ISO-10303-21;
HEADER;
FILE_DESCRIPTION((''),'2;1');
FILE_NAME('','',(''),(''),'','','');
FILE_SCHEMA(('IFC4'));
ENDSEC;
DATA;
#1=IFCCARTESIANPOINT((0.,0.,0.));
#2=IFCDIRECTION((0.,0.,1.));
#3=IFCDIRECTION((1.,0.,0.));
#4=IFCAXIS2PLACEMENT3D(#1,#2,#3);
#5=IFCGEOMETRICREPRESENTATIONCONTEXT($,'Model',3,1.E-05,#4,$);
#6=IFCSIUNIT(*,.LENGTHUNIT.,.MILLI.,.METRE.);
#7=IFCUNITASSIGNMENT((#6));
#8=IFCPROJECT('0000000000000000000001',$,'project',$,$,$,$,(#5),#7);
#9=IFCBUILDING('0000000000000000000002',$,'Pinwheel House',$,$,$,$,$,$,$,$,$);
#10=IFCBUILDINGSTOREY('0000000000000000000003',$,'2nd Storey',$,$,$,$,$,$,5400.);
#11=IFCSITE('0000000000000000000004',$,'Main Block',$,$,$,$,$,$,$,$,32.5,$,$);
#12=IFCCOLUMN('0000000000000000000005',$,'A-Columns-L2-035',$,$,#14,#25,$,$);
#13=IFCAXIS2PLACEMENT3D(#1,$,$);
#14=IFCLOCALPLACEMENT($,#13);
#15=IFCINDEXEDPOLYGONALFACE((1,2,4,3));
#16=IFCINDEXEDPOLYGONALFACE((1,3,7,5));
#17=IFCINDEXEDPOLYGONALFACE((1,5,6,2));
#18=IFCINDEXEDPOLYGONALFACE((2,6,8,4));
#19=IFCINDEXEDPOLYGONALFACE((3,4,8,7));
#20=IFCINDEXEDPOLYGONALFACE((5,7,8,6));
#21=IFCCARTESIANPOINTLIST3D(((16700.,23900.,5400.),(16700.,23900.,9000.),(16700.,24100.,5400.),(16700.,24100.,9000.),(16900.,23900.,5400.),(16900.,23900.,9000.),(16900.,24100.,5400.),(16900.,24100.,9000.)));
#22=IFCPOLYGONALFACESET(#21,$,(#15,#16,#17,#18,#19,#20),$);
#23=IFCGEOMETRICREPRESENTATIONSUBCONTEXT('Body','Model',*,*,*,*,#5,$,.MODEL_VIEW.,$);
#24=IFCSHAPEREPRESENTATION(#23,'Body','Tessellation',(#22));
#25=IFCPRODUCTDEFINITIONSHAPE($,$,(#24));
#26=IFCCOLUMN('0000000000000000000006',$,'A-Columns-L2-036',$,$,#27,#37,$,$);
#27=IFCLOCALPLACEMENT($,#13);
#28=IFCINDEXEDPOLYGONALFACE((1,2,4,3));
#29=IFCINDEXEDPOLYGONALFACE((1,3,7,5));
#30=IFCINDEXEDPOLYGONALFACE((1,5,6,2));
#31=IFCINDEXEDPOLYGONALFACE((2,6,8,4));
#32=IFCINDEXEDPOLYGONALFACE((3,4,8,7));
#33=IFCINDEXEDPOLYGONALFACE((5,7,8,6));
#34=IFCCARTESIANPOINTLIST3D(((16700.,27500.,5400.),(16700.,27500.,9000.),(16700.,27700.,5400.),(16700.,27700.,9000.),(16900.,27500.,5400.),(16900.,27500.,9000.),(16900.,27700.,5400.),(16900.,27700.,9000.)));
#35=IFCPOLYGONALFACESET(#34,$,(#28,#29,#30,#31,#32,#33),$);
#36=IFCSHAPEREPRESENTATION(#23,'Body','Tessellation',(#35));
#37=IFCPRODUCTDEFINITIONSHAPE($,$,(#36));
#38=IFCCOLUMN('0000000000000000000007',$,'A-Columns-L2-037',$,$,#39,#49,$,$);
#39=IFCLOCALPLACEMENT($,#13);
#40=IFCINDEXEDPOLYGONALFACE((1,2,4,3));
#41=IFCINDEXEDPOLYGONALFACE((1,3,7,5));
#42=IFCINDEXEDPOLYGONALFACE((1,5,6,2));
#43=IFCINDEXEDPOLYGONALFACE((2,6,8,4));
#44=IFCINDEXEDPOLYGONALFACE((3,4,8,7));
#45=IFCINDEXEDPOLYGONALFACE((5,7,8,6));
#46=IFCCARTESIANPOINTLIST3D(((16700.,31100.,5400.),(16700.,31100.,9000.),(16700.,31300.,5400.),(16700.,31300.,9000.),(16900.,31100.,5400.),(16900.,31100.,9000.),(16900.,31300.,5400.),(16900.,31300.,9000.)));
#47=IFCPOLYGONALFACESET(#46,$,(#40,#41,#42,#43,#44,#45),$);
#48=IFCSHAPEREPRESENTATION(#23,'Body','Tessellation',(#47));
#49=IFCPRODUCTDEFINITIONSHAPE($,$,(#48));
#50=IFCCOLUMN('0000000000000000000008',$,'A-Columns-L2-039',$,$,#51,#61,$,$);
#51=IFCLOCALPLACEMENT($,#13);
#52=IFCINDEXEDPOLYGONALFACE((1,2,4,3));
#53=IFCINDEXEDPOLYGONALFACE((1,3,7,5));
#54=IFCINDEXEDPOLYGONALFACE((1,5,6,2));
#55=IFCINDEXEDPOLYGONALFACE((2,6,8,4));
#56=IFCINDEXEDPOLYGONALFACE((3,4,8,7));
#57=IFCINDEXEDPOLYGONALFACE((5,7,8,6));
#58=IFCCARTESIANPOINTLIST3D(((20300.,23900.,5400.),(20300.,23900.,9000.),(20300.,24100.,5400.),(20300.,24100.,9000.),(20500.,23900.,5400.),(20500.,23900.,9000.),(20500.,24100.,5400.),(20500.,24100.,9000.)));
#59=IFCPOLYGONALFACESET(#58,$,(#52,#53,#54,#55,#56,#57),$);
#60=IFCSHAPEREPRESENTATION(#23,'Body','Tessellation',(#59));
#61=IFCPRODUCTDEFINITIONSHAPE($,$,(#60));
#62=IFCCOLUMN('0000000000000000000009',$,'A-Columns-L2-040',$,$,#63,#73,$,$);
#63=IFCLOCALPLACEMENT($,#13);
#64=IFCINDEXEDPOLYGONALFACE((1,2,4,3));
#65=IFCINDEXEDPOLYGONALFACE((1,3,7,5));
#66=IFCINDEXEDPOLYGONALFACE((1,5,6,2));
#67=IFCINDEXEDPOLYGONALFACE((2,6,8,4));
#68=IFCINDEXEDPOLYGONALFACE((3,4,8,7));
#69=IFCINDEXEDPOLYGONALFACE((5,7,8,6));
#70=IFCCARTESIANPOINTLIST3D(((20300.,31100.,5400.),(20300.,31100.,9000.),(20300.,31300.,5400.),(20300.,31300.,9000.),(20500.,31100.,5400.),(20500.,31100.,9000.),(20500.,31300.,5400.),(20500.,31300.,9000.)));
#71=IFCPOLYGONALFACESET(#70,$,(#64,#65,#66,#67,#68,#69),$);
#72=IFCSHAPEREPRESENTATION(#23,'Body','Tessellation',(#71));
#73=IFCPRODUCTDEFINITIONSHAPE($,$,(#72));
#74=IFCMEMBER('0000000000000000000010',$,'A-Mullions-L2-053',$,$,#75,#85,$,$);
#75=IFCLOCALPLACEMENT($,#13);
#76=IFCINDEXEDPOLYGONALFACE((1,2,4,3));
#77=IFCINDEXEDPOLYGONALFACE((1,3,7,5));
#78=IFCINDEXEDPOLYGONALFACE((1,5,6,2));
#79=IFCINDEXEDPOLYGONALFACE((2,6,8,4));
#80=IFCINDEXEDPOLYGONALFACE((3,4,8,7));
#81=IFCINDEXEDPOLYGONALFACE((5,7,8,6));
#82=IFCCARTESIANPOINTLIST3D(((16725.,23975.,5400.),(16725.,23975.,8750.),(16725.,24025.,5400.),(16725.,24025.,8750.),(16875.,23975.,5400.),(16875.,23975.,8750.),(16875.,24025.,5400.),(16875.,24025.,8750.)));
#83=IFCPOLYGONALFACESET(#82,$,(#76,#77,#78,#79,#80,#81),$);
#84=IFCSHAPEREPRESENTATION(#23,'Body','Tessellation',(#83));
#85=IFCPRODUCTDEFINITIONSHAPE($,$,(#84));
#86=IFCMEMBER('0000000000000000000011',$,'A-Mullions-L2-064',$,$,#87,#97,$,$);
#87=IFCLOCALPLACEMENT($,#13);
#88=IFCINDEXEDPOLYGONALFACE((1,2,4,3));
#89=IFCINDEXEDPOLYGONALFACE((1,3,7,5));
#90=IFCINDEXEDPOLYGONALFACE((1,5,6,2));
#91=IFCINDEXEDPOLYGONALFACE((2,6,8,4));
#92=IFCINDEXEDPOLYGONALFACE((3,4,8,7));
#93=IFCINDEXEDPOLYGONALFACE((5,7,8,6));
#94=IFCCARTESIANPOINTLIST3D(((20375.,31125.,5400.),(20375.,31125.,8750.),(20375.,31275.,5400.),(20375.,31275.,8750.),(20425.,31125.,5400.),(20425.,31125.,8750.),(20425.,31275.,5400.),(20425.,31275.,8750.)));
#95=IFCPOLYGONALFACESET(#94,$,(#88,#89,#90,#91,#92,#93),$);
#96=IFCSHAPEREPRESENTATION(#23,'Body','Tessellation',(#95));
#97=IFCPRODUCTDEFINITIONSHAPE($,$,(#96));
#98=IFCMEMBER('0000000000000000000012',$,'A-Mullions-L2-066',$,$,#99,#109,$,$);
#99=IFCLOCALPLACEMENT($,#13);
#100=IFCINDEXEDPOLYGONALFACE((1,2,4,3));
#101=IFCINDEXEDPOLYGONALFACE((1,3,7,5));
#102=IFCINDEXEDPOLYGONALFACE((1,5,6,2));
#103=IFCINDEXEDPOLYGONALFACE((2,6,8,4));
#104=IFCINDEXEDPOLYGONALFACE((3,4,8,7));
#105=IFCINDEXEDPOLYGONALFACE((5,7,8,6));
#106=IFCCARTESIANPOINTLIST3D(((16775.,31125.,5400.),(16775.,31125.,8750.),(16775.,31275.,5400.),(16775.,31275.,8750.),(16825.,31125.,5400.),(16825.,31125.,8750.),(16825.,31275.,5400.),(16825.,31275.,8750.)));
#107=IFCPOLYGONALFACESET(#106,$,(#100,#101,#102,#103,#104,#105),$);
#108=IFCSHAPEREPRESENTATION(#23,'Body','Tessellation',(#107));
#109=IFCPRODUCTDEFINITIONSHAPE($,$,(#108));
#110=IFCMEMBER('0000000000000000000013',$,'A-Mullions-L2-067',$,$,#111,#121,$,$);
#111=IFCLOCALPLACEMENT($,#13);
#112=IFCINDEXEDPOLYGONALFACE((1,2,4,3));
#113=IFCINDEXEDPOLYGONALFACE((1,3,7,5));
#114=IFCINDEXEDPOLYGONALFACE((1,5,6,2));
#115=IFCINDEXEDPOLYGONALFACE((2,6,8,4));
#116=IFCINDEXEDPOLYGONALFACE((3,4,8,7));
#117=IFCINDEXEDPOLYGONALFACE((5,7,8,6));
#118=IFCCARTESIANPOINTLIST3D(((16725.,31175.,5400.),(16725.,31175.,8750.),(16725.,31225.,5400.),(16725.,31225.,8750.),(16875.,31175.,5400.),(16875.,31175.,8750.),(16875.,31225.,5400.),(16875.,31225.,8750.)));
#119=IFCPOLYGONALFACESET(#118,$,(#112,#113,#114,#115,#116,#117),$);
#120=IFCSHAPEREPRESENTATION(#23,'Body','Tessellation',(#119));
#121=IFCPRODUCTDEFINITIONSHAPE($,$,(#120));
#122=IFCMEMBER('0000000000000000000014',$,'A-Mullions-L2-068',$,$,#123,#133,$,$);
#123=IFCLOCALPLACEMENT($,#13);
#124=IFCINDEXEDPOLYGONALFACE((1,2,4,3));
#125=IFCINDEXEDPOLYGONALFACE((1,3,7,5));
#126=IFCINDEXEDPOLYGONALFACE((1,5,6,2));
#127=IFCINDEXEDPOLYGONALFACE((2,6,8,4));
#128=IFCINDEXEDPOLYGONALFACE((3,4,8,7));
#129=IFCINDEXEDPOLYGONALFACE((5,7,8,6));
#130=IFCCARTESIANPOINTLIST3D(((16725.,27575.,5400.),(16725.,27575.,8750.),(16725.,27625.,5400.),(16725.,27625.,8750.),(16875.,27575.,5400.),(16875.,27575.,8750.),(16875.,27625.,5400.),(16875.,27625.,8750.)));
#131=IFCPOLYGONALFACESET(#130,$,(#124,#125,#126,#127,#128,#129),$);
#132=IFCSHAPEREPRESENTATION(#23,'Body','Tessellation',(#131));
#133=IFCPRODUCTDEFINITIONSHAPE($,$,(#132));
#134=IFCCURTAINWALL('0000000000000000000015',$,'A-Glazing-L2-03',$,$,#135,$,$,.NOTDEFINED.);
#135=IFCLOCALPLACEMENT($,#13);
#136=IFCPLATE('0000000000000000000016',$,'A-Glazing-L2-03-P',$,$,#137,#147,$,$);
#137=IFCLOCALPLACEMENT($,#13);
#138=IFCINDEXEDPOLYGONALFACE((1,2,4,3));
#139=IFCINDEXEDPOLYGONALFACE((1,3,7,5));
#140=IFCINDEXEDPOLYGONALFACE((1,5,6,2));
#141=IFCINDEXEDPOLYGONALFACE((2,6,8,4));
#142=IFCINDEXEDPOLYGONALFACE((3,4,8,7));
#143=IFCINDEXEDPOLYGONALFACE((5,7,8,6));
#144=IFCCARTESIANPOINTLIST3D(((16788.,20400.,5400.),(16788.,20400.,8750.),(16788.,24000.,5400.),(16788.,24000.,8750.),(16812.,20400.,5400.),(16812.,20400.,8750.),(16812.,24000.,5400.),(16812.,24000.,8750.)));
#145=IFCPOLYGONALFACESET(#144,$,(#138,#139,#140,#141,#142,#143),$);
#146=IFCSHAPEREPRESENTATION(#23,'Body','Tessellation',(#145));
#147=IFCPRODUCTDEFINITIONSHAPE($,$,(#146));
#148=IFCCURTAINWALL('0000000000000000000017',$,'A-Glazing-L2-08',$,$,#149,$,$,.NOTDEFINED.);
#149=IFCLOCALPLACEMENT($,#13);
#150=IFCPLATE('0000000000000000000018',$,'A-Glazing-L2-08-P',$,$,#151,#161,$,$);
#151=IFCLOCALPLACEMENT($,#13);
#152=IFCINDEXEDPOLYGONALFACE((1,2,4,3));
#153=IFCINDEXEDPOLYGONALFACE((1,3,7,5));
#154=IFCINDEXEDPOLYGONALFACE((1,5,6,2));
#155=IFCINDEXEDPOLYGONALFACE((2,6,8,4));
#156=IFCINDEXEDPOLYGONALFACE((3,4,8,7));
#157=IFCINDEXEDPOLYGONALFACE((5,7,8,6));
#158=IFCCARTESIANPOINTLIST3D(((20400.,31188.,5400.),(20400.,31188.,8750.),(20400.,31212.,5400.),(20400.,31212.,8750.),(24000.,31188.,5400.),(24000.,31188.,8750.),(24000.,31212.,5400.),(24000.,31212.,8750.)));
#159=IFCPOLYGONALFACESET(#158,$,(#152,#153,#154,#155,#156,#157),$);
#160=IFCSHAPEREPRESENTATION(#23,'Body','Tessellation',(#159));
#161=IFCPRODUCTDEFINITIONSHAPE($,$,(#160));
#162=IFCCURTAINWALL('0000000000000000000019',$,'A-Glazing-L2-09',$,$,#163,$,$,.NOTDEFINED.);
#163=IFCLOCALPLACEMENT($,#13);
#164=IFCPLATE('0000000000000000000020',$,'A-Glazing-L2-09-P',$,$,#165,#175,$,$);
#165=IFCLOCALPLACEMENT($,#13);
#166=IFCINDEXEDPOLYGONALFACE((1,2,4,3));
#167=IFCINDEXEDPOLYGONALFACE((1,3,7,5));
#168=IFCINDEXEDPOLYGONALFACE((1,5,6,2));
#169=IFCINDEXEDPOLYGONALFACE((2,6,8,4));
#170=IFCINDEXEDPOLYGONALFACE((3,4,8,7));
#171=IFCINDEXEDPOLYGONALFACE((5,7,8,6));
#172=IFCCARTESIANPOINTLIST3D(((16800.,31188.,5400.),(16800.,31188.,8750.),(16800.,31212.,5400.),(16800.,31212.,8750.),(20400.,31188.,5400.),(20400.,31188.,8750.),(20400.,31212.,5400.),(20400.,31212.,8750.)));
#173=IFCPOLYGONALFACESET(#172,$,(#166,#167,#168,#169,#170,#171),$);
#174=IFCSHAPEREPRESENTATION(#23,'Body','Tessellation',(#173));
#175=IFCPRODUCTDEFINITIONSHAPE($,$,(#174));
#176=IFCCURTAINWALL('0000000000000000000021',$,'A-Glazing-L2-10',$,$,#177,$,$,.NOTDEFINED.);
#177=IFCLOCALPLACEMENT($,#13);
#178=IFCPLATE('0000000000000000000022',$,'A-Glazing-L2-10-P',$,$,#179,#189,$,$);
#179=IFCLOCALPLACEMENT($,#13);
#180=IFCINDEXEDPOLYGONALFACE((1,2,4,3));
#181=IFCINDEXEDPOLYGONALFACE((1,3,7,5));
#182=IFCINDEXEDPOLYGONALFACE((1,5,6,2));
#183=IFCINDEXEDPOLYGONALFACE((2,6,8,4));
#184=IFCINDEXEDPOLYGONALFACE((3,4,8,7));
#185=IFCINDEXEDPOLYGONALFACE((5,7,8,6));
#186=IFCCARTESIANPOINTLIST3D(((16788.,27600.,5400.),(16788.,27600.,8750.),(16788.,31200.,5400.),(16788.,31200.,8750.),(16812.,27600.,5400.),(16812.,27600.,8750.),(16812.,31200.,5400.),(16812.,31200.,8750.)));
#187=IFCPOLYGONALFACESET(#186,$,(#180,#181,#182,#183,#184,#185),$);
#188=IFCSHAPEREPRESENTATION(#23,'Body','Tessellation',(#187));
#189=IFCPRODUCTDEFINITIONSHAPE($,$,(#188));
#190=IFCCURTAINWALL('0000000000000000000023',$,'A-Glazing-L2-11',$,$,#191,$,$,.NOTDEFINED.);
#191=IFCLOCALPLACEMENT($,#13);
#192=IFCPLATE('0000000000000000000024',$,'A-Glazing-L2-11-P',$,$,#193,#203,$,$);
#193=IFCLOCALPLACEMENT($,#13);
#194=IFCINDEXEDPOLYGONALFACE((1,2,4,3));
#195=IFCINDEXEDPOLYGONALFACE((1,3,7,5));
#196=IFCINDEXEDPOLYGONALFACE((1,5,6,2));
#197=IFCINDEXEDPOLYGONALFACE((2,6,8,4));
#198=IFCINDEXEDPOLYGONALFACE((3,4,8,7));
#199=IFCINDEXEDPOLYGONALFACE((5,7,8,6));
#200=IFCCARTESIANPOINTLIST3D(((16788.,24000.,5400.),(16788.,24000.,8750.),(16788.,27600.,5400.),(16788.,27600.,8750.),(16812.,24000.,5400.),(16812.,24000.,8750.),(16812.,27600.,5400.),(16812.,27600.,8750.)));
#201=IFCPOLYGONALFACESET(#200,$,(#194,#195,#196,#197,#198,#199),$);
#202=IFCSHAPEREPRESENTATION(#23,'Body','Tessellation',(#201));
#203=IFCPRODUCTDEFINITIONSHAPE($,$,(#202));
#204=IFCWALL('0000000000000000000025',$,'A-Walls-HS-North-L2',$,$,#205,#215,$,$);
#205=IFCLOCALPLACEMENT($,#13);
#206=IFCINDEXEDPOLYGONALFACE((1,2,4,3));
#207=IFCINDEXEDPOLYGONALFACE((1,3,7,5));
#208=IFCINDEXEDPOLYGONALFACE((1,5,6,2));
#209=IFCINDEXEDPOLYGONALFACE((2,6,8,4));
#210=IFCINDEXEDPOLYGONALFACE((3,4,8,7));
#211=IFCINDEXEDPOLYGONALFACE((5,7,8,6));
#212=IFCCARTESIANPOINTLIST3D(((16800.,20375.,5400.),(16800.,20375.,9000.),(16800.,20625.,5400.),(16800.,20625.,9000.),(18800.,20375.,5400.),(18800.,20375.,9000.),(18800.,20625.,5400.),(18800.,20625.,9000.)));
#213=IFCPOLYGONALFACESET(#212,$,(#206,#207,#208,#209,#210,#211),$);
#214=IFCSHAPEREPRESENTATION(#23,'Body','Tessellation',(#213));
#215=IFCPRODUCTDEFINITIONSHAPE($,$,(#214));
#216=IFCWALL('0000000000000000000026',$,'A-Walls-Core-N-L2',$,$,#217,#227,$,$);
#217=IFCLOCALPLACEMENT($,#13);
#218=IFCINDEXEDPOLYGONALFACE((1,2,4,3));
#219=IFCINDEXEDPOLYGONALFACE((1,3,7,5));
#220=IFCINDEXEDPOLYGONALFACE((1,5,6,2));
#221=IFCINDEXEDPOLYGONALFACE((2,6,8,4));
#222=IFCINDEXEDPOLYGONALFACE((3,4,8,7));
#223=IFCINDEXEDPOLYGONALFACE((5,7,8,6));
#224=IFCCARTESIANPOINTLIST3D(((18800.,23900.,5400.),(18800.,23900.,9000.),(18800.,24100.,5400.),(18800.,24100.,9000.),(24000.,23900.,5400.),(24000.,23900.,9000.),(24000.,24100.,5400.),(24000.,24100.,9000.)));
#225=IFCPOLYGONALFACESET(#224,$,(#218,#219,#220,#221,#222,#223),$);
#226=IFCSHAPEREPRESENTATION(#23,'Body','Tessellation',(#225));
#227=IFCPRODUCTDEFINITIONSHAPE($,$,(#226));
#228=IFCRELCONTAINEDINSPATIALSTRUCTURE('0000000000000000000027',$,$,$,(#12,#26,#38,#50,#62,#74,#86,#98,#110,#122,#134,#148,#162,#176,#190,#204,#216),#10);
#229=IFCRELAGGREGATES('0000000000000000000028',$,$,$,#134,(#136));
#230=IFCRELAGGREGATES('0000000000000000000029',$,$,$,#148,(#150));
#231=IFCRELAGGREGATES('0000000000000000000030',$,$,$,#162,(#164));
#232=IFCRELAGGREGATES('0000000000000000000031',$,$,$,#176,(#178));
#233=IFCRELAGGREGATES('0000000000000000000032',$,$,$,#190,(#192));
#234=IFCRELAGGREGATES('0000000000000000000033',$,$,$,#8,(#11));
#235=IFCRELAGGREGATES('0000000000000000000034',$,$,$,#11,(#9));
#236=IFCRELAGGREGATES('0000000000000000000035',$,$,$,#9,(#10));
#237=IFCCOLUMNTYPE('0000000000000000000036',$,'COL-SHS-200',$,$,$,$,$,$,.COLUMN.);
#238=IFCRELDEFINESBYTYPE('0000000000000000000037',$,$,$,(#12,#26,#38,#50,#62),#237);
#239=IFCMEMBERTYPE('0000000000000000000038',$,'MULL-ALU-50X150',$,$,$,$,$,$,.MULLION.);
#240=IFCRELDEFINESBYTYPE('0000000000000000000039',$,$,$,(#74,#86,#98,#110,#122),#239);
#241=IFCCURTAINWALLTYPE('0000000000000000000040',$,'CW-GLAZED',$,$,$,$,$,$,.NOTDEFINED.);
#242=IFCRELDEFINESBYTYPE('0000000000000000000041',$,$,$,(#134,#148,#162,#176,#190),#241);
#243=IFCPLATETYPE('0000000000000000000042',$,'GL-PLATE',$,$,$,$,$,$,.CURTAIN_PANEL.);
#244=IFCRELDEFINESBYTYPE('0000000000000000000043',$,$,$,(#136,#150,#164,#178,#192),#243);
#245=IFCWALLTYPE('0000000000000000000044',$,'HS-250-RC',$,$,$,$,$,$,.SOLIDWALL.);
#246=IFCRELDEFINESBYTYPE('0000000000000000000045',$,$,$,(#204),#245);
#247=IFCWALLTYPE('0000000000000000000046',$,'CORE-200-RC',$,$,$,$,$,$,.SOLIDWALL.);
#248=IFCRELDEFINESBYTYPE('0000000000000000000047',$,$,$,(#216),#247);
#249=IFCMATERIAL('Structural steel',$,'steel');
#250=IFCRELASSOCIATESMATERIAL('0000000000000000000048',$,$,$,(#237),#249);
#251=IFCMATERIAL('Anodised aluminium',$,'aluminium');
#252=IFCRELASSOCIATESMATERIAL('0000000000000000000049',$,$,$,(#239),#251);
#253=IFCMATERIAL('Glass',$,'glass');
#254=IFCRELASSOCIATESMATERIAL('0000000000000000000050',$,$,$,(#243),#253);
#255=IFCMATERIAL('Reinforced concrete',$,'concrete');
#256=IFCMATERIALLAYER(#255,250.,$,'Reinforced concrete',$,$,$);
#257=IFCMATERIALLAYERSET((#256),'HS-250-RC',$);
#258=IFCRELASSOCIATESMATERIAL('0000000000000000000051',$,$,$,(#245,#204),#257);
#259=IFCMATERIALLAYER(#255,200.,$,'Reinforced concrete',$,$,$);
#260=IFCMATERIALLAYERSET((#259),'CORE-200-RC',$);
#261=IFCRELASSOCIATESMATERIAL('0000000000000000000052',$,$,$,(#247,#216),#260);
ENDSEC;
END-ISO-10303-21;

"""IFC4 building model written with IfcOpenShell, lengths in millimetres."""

from ifc_helpers import new_model, si_unit, frame, origin_with_axes, place, context, subcontext, project, spatial, indexed_curve, outline, extrude, material, layer, layer_set, layer_usage, type_object, element, aggregate, save


model = new_model("IFC4")

# Units and contexts
model_context = context("Model", 3, precision=1e-05, world=origin_with_axes())
body_context = subcontext(model_context, "Body", "Model", "MODEL_VIEW")
ifc_project = project(units=[si_unit("LENGTHUNIT", "METRE", prefix="MILLI")], contexts=[model_context])

# Site, building, storey
site = spatial("IfcSite", under=ifc_project, Name="Main Block", RefElevation=32.5)
building = spatial("IfcBuilding", under=site, Name="Pinwheel House")
storey = spatial("IfcBuildingStorey", under=building, Name="2nd Storey", Elevation=5400.0)

# Columns
ifc_material_1 = material(Name="Structural steel", Category="steel")
column_type = type_object("IfcColumnType", Name="COL-SHS-200", PredefinedType="COLUMN", material=ifc_material_1)
for number, where, z_axis, x_axis, name in (
    (1, (16800.0, 24000.0, 5400.0), (0.0, 0.0, 1.0), (1.0, 0.0, 0.0), "A-Columns-L2-035"),
    (2, (16800.0, 27600.0, 5400.0), (0.0, 0.0, 1.0), (1.0, 0.0, 0.0), "A-Columns-L2-036"),
    (3, (16800.0, 31200.0, 5400.0), (0.0, 0.0, 1.0), (1.0, 0.0, 0.0), "A-Columns-L2-037"),
    (4, (20400.0, 24000.0, 5400.0), (0.0, 0.0, 1.0), (1.0, 0.0, 0.0), "A-Columns-L2-039"),
    (5, (20400.0, 31200.0, 5400.0), (0.0, 0.0, 1.0), (1.0, 0.0, 0.0), "A-Columns-L2-040"),
):
    element("IfcColumn", number, at=place(None, frame(where, z_axis=z_axis, x_axis=x_axis)), inside=storey, type_object=column_type, Name=name, context=body_context, shape_type="SweptSolid", body=[
        extrude(outline(indexed_curve([(-100.0, -100.0), (100.0, -100.0), (100.0, 100.0), (-100.0, 100.0)])), None, (0.0, 0.0, 1.0), 3600.0),
    ])

# Members
ifc_material_2 = material(Name="Anodised aluminium", Category="aluminium")
member_type = type_object("IfcMemberType", Name="MULL-ALU-50X150", PredefinedType="MULLION", material=ifc_material_2)
for number, where, z_axis, x_axis, name in (
    (6, (16800.0, 24000.0, 5400.0), (0.0, 0.0, 1.0), (0.0, -1.0, 0.0), "A-Mullions-L2-053"),
    (7, (20400.0, 31200.0, 5400.0), (0.0, 0.0, 1.0), (-1.0, 0.0, 0.0), "A-Mullions-L2-064"),
    (8, (16800.0, 31200.0, 5400.0), (0.0, 0.0, 1.0), (-1.0, 0.0, 0.0), "A-Mullions-L2-066"),
    (9, (16800.0, 31200.0, 5400.0), (0.0, 0.0, 1.0), (0.0, -1.0, 0.0), "A-Mullions-L2-067"),
    (10, (16800.0, 27600.0, 5400.0), (0.0, 0.0, 1.0), (0.0, -1.0, 0.0), "A-Mullions-L2-068"),
):
    element("IfcMember", number, at=place(None, frame(where, z_axis=z_axis, x_axis=x_axis)), inside=storey, type_object=member_type, Name=name, context=body_context, shape_type="SweptSolid", body=[
        extrude(outline(indexed_curve([(-25.0, -75.0), (25.0, -75.0), (25.0, 75.0), (-25.0, 75.0)])), None, (0.0, 0.0, 1.0), 3350.0),
    ])

# Curtain walls, plates
curtain_wall_type = type_object("IfcCurtainWallType", Name="CW-GLAZED", PredefinedType="NOTDEFINED")
curtain_wall_1 = element("IfcCurtainWall", 11, inside=storey, type_object=curtain_wall_type, Name="A-Glazing-L2-03", PredefinedType="NOTDEFINED")
ifc_material_3 = material(Name="Glass", Category="glass")
plate_type = type_object("IfcPlateType", Name="GL-PLATE", PredefinedType="CURTAIN_PANEL", material=ifc_material_3)
plate_1_placement = place(None, frame((16800.0, 22200.0, 5400.0), z_axis=(0.0, 0.0, 1.0), x_axis=(0.0, -1.0, 0.0)))
plate_1 = element("IfcPlate", 12, at=plate_1_placement, type_object=plate_type, Name="A-Glazing-L2-03-P", context=body_context, shape_type="SweptSolid", body=[
    extrude(outline(indexed_curve([(-1800.0, -12.0), (1800.0, -12.0), (1800.0, 12.0), (-1800.0, 12.0)])), None, (0.0, 0.0, 1.0), 3350.0),
])
aggregate(curtain_wall_1, [plate_1])
curtain_wall_2 = element("IfcCurtainWall", 13, inside=storey, type_object=curtain_wall_type, Name="A-Glazing-L2-08", PredefinedType="NOTDEFINED")
plate_2_placement = place(None, frame((22200.0, 31200.0, 5400.0), z_axis=(0.0, 0.0, 1.0), x_axis=(-1.0, 0.0, 0.0)))
plate_2 = element("IfcPlate", 14, at=plate_2_placement, type_object=plate_type, Name="A-Glazing-L2-08-P", context=body_context, shape_type="SweptSolid", body=[
    extrude(outline(indexed_curve([(-1800.0, -12.0), (1800.0, -12.0), (1800.0, 12.0), (-1800.0, 12.0)])), None, (0.0, 0.0, 1.0), 3350.0),
])
aggregate(curtain_wall_2, [plate_2])
curtain_wall_3 = element("IfcCurtainWall", 15, inside=storey, type_object=curtain_wall_type, Name="A-Glazing-L2-09", PredefinedType="NOTDEFINED")
plate_3_placement = place(None, frame((18600.0, 31200.0, 5400.0), z_axis=(0.0, 0.0, 1.0), x_axis=(-1.0, 0.0, 0.0)))
plate_3 = element("IfcPlate", 16, at=plate_3_placement, type_object=plate_type, Name="A-Glazing-L2-09-P", context=body_context, shape_type="SweptSolid", body=[
    extrude(outline(indexed_curve([(-1800.0, -12.0), (1800.0, -12.0), (1800.0, 12.0), (-1800.0, 12.0)])), None, (0.0, 0.0, 1.0), 3350.0),
])
aggregate(curtain_wall_3, [plate_3])
curtain_wall_4 = element("IfcCurtainWall", 17, inside=storey, type_object=curtain_wall_type, Name="A-Glazing-L2-10", PredefinedType="NOTDEFINED")
plate_4_placement = place(None, frame((16800.0, 29400.0, 5400.0), z_axis=(0.0, 0.0, 1.0), x_axis=(0.0, -1.0, 0.0)))
plate_4 = element("IfcPlate", 18, at=plate_4_placement, type_object=plate_type, Name="A-Glazing-L2-10-P", context=body_context, shape_type="SweptSolid", body=[
    extrude(outline(indexed_curve([(-1800.0, -12.0), (1800.0, -12.0), (1800.0, 12.0), (-1800.0, 12.0)])), None, (0.0, 0.0, 1.0), 3350.0),
])
aggregate(curtain_wall_4, [plate_4])
curtain_wall_5 = element("IfcCurtainWall", 19, inside=storey, type_object=curtain_wall_type, Name="A-Glazing-L2-11", PredefinedType="NOTDEFINED")
plate_5_placement = place(None, frame((16800.0, 25800.0, 5400.0), z_axis=(0.0, 0.0, 1.0), x_axis=(0.0, -1.0, 0.0)))
plate_5 = element("IfcPlate", 20, at=plate_5_placement, type_object=plate_type, Name="A-Glazing-L2-11-P", context=body_context, shape_type="SweptSolid", body=[
    extrude(outline(indexed_curve([(-1800.0, -12.0), (1800.0, -12.0), (1800.0, 12.0), (-1800.0, 12.0)])), None, (0.0, 0.0, 1.0), 3350.0),
])
aggregate(curtain_wall_5, [plate_5])

# Walls
ifc_material_4 = material(Name="Reinforced concrete", Category="concrete")
ifc_layer_1 = layer(ifc_material_4, 250.0, Name="Reinforced concrete")
ifc_layer_set_1 = layer_set([ifc_layer_1], Name="HS-250-RC")
ifc_layer_usage_1 = layer_usage(ifc_layer_set_1, "AXIS2", "POSITIVE", 0.0)
wall_type_1 = type_object("IfcWallType", Name="HS-250-RC", PredefinedType="SOLIDWALL", material=ifc_layer_set_1)
wall_1_placement = place(None, frame((18800.0, 20625.0, 5400.0), z_axis=(0.0, 0.0, 1.0), x_axis=(-1.0, 0.0, 0.0)))
element("IfcWall", 21, at=wall_1_placement, inside=storey, type_object=wall_type_1, material=ifc_layer_usage_1, Name="A-Walls-HS-North-L2", context=body_context, shape_type="SweptSolid", body=[
    extrude(outline(indexed_curve([(0.0, 0.0), (0.0, 250.0), (2000.0, 250.0), (2000.0, 0.0), (0.0, 0.0)], self_intersect=False)), origin_with_axes(), (0.0, 0.0, 1.0), 3600.0),
])
ifc_layer_2 = layer(ifc_material_4, 200.0, Name="Reinforced concrete")
ifc_layer_set_2 = layer_set([ifc_layer_2], Name="CORE-200-RC")
ifc_layer_usage_2 = layer_usage(ifc_layer_set_2, "AXIS2", "POSITIVE", 0.0)
wall_type_2 = type_object("IfcWallType", Name="CORE-200-RC", PredefinedType="SOLIDWALL", material=ifc_layer_set_2)
wall_2_placement = place(None, frame((18800.0, 23900.0, 5400.0), z_axis=(0.0, 0.0, 1.0), x_axis=(1.0, 0.0, 0.0)))
element("IfcWall", 22, at=wall_2_placement, inside=storey, type_object=wall_type_2, material=ifc_layer_usage_2, Name="A-Walls-Core-N-L2", context=body_context, shape_type="SweptSolid", body=[
    extrude(outline(indexed_curve([(0.0, 0.0), (0.0, 200.0), (5200.0, 200.0), (5200.0, 0.0), (0.0, 0.0)], self_intersect=False)), origin_with_axes(), (0.0, 0.0, 1.0), 3600.0),
])

save(model, "model.ifc")
